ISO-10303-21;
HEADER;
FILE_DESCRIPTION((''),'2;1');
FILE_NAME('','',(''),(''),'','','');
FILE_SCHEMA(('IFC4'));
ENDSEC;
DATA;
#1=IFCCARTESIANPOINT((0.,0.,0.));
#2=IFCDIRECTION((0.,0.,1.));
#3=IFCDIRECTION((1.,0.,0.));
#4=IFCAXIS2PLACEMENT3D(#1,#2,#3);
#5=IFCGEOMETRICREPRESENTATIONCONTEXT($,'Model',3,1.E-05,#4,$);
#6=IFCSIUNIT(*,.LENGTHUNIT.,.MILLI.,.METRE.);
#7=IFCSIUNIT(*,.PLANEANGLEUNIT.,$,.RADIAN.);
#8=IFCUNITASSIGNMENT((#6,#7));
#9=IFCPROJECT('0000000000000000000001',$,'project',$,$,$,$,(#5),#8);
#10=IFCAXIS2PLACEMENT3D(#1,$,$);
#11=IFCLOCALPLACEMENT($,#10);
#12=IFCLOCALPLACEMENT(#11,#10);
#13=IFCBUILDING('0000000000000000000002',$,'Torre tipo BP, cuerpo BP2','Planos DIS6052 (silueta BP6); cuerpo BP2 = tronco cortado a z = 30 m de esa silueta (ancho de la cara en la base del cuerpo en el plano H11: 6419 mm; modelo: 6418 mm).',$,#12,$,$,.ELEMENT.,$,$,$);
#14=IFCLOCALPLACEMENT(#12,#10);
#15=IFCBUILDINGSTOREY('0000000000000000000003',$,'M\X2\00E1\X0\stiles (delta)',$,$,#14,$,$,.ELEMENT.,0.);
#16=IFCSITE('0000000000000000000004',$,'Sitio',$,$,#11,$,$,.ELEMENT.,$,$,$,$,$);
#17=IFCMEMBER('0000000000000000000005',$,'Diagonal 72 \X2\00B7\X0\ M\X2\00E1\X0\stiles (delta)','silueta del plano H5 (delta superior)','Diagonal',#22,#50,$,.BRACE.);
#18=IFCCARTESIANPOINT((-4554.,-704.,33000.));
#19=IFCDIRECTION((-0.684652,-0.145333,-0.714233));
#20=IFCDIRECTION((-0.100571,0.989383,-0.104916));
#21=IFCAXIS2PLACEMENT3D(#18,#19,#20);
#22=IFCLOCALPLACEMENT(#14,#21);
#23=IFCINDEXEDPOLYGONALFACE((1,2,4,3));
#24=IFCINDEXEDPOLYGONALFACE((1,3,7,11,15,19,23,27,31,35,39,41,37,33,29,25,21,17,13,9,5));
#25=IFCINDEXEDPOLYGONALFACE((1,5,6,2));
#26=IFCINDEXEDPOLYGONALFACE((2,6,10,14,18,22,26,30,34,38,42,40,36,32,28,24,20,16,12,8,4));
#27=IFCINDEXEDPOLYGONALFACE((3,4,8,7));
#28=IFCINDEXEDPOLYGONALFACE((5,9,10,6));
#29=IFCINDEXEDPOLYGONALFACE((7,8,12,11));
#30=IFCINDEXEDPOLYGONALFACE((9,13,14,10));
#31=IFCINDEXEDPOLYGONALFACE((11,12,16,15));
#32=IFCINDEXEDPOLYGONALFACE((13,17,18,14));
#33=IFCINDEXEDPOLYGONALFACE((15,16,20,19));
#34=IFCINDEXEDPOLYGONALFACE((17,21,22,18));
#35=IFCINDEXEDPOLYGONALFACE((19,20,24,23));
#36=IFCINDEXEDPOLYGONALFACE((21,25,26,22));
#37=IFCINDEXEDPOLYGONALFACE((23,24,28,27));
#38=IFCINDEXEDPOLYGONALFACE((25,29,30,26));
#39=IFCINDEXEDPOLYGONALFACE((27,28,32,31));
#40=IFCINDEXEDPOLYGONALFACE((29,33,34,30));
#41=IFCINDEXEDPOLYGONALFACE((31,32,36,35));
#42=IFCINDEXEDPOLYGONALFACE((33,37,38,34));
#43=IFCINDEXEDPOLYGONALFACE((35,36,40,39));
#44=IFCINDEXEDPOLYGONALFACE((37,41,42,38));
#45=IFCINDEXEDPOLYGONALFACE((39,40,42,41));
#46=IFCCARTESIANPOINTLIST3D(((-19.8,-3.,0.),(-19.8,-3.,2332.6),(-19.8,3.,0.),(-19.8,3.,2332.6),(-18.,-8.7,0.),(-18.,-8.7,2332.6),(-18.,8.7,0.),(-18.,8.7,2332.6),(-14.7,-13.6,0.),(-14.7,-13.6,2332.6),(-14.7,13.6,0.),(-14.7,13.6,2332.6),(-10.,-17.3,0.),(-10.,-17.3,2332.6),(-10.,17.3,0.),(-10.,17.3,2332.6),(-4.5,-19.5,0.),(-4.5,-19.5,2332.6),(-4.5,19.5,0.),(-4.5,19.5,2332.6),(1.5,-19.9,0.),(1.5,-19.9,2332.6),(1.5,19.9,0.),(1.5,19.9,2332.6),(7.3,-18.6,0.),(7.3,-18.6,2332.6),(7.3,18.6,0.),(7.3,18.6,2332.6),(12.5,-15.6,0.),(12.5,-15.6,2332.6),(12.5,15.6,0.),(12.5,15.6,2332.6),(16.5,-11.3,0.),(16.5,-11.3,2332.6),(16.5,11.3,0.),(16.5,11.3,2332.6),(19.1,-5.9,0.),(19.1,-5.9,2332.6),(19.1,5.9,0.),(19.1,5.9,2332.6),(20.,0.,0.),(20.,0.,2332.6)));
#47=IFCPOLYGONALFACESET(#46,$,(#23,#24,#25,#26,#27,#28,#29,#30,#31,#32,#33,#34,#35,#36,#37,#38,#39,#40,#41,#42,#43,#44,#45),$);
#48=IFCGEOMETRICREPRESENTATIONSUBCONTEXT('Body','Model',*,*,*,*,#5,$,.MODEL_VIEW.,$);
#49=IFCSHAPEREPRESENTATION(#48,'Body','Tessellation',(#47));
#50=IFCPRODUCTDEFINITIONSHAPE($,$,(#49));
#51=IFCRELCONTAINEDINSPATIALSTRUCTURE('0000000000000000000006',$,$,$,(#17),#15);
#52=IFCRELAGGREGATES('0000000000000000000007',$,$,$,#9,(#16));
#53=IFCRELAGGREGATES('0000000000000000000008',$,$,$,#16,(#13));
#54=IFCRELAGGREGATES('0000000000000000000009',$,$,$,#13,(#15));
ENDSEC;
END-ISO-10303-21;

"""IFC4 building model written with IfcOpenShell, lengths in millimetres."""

from ifc_helpers import new_model, si_unit, frame, origin, origin_with_axes, place, context, subcontext, project, spatial, circle, extrude, element, save


model = new_model("IFC4")

# Units and contexts
model_context = context("Model", 3, precision=1e-05, world=origin_with_axes())
body_context = subcontext(model_context, "Body", "Model", "MODEL_VIEW")
ifc_project = project(units=[si_unit("LENGTHUNIT", "METRE", prefix="MILLI"), si_unit("PLANEANGLEUNIT", "RADIAN")], contexts=[model_context])

# Site, building, storey
site_placement = place(None, origin())
site = spatial("IfcSite", under=ifc_project, at=site_placement, Name="Sitio", CompositionType="ELEMENT")
building_placement = place(site_placement, origin())
building = spatial("IfcBuilding", under=site, at=building_placement, Name="Torre tipo BP, cuerpo BP2", Description="Planos DIS6052 (silueta BP6); cuerpo BP2 = tronco cortado a z = 30 m de esa silueta (ancho de la cara en la base del cuerpo en el plano H11: 6419 mm; modelo: 6418 mm).", CompositionType="ELEMENT")
storey_placement = place(building_placement, origin())
storey = spatial("IfcBuildingStorey", under=building, at=storey_placement, Name="Mástiles (delta)", CompositionType="ELEMENT", Elevation=0.0)

# Member
member_1_placement = place(storey_placement, frame((-4554.0, -704.0, 33000.0), z_axis=(-0.684652, -0.145333, -0.714233), x_axis=(-0.100571, 0.989383, -0.104916)))
element("IfcMember", 1, at=member_1_placement, inside=storey, Name="Diagonal 72 · Mástiles (delta)", Description="silueta del plano H5 (delta superior)", ObjectType="Diagonal", PredefinedType="BRACE", context=body_context, shape_type="SweptSolid", body=[
    extrude(circle(Radius=20.0), None, (0.0, 0.0, 1.0), 2332.6),
])

save(model, "model.ifc")
